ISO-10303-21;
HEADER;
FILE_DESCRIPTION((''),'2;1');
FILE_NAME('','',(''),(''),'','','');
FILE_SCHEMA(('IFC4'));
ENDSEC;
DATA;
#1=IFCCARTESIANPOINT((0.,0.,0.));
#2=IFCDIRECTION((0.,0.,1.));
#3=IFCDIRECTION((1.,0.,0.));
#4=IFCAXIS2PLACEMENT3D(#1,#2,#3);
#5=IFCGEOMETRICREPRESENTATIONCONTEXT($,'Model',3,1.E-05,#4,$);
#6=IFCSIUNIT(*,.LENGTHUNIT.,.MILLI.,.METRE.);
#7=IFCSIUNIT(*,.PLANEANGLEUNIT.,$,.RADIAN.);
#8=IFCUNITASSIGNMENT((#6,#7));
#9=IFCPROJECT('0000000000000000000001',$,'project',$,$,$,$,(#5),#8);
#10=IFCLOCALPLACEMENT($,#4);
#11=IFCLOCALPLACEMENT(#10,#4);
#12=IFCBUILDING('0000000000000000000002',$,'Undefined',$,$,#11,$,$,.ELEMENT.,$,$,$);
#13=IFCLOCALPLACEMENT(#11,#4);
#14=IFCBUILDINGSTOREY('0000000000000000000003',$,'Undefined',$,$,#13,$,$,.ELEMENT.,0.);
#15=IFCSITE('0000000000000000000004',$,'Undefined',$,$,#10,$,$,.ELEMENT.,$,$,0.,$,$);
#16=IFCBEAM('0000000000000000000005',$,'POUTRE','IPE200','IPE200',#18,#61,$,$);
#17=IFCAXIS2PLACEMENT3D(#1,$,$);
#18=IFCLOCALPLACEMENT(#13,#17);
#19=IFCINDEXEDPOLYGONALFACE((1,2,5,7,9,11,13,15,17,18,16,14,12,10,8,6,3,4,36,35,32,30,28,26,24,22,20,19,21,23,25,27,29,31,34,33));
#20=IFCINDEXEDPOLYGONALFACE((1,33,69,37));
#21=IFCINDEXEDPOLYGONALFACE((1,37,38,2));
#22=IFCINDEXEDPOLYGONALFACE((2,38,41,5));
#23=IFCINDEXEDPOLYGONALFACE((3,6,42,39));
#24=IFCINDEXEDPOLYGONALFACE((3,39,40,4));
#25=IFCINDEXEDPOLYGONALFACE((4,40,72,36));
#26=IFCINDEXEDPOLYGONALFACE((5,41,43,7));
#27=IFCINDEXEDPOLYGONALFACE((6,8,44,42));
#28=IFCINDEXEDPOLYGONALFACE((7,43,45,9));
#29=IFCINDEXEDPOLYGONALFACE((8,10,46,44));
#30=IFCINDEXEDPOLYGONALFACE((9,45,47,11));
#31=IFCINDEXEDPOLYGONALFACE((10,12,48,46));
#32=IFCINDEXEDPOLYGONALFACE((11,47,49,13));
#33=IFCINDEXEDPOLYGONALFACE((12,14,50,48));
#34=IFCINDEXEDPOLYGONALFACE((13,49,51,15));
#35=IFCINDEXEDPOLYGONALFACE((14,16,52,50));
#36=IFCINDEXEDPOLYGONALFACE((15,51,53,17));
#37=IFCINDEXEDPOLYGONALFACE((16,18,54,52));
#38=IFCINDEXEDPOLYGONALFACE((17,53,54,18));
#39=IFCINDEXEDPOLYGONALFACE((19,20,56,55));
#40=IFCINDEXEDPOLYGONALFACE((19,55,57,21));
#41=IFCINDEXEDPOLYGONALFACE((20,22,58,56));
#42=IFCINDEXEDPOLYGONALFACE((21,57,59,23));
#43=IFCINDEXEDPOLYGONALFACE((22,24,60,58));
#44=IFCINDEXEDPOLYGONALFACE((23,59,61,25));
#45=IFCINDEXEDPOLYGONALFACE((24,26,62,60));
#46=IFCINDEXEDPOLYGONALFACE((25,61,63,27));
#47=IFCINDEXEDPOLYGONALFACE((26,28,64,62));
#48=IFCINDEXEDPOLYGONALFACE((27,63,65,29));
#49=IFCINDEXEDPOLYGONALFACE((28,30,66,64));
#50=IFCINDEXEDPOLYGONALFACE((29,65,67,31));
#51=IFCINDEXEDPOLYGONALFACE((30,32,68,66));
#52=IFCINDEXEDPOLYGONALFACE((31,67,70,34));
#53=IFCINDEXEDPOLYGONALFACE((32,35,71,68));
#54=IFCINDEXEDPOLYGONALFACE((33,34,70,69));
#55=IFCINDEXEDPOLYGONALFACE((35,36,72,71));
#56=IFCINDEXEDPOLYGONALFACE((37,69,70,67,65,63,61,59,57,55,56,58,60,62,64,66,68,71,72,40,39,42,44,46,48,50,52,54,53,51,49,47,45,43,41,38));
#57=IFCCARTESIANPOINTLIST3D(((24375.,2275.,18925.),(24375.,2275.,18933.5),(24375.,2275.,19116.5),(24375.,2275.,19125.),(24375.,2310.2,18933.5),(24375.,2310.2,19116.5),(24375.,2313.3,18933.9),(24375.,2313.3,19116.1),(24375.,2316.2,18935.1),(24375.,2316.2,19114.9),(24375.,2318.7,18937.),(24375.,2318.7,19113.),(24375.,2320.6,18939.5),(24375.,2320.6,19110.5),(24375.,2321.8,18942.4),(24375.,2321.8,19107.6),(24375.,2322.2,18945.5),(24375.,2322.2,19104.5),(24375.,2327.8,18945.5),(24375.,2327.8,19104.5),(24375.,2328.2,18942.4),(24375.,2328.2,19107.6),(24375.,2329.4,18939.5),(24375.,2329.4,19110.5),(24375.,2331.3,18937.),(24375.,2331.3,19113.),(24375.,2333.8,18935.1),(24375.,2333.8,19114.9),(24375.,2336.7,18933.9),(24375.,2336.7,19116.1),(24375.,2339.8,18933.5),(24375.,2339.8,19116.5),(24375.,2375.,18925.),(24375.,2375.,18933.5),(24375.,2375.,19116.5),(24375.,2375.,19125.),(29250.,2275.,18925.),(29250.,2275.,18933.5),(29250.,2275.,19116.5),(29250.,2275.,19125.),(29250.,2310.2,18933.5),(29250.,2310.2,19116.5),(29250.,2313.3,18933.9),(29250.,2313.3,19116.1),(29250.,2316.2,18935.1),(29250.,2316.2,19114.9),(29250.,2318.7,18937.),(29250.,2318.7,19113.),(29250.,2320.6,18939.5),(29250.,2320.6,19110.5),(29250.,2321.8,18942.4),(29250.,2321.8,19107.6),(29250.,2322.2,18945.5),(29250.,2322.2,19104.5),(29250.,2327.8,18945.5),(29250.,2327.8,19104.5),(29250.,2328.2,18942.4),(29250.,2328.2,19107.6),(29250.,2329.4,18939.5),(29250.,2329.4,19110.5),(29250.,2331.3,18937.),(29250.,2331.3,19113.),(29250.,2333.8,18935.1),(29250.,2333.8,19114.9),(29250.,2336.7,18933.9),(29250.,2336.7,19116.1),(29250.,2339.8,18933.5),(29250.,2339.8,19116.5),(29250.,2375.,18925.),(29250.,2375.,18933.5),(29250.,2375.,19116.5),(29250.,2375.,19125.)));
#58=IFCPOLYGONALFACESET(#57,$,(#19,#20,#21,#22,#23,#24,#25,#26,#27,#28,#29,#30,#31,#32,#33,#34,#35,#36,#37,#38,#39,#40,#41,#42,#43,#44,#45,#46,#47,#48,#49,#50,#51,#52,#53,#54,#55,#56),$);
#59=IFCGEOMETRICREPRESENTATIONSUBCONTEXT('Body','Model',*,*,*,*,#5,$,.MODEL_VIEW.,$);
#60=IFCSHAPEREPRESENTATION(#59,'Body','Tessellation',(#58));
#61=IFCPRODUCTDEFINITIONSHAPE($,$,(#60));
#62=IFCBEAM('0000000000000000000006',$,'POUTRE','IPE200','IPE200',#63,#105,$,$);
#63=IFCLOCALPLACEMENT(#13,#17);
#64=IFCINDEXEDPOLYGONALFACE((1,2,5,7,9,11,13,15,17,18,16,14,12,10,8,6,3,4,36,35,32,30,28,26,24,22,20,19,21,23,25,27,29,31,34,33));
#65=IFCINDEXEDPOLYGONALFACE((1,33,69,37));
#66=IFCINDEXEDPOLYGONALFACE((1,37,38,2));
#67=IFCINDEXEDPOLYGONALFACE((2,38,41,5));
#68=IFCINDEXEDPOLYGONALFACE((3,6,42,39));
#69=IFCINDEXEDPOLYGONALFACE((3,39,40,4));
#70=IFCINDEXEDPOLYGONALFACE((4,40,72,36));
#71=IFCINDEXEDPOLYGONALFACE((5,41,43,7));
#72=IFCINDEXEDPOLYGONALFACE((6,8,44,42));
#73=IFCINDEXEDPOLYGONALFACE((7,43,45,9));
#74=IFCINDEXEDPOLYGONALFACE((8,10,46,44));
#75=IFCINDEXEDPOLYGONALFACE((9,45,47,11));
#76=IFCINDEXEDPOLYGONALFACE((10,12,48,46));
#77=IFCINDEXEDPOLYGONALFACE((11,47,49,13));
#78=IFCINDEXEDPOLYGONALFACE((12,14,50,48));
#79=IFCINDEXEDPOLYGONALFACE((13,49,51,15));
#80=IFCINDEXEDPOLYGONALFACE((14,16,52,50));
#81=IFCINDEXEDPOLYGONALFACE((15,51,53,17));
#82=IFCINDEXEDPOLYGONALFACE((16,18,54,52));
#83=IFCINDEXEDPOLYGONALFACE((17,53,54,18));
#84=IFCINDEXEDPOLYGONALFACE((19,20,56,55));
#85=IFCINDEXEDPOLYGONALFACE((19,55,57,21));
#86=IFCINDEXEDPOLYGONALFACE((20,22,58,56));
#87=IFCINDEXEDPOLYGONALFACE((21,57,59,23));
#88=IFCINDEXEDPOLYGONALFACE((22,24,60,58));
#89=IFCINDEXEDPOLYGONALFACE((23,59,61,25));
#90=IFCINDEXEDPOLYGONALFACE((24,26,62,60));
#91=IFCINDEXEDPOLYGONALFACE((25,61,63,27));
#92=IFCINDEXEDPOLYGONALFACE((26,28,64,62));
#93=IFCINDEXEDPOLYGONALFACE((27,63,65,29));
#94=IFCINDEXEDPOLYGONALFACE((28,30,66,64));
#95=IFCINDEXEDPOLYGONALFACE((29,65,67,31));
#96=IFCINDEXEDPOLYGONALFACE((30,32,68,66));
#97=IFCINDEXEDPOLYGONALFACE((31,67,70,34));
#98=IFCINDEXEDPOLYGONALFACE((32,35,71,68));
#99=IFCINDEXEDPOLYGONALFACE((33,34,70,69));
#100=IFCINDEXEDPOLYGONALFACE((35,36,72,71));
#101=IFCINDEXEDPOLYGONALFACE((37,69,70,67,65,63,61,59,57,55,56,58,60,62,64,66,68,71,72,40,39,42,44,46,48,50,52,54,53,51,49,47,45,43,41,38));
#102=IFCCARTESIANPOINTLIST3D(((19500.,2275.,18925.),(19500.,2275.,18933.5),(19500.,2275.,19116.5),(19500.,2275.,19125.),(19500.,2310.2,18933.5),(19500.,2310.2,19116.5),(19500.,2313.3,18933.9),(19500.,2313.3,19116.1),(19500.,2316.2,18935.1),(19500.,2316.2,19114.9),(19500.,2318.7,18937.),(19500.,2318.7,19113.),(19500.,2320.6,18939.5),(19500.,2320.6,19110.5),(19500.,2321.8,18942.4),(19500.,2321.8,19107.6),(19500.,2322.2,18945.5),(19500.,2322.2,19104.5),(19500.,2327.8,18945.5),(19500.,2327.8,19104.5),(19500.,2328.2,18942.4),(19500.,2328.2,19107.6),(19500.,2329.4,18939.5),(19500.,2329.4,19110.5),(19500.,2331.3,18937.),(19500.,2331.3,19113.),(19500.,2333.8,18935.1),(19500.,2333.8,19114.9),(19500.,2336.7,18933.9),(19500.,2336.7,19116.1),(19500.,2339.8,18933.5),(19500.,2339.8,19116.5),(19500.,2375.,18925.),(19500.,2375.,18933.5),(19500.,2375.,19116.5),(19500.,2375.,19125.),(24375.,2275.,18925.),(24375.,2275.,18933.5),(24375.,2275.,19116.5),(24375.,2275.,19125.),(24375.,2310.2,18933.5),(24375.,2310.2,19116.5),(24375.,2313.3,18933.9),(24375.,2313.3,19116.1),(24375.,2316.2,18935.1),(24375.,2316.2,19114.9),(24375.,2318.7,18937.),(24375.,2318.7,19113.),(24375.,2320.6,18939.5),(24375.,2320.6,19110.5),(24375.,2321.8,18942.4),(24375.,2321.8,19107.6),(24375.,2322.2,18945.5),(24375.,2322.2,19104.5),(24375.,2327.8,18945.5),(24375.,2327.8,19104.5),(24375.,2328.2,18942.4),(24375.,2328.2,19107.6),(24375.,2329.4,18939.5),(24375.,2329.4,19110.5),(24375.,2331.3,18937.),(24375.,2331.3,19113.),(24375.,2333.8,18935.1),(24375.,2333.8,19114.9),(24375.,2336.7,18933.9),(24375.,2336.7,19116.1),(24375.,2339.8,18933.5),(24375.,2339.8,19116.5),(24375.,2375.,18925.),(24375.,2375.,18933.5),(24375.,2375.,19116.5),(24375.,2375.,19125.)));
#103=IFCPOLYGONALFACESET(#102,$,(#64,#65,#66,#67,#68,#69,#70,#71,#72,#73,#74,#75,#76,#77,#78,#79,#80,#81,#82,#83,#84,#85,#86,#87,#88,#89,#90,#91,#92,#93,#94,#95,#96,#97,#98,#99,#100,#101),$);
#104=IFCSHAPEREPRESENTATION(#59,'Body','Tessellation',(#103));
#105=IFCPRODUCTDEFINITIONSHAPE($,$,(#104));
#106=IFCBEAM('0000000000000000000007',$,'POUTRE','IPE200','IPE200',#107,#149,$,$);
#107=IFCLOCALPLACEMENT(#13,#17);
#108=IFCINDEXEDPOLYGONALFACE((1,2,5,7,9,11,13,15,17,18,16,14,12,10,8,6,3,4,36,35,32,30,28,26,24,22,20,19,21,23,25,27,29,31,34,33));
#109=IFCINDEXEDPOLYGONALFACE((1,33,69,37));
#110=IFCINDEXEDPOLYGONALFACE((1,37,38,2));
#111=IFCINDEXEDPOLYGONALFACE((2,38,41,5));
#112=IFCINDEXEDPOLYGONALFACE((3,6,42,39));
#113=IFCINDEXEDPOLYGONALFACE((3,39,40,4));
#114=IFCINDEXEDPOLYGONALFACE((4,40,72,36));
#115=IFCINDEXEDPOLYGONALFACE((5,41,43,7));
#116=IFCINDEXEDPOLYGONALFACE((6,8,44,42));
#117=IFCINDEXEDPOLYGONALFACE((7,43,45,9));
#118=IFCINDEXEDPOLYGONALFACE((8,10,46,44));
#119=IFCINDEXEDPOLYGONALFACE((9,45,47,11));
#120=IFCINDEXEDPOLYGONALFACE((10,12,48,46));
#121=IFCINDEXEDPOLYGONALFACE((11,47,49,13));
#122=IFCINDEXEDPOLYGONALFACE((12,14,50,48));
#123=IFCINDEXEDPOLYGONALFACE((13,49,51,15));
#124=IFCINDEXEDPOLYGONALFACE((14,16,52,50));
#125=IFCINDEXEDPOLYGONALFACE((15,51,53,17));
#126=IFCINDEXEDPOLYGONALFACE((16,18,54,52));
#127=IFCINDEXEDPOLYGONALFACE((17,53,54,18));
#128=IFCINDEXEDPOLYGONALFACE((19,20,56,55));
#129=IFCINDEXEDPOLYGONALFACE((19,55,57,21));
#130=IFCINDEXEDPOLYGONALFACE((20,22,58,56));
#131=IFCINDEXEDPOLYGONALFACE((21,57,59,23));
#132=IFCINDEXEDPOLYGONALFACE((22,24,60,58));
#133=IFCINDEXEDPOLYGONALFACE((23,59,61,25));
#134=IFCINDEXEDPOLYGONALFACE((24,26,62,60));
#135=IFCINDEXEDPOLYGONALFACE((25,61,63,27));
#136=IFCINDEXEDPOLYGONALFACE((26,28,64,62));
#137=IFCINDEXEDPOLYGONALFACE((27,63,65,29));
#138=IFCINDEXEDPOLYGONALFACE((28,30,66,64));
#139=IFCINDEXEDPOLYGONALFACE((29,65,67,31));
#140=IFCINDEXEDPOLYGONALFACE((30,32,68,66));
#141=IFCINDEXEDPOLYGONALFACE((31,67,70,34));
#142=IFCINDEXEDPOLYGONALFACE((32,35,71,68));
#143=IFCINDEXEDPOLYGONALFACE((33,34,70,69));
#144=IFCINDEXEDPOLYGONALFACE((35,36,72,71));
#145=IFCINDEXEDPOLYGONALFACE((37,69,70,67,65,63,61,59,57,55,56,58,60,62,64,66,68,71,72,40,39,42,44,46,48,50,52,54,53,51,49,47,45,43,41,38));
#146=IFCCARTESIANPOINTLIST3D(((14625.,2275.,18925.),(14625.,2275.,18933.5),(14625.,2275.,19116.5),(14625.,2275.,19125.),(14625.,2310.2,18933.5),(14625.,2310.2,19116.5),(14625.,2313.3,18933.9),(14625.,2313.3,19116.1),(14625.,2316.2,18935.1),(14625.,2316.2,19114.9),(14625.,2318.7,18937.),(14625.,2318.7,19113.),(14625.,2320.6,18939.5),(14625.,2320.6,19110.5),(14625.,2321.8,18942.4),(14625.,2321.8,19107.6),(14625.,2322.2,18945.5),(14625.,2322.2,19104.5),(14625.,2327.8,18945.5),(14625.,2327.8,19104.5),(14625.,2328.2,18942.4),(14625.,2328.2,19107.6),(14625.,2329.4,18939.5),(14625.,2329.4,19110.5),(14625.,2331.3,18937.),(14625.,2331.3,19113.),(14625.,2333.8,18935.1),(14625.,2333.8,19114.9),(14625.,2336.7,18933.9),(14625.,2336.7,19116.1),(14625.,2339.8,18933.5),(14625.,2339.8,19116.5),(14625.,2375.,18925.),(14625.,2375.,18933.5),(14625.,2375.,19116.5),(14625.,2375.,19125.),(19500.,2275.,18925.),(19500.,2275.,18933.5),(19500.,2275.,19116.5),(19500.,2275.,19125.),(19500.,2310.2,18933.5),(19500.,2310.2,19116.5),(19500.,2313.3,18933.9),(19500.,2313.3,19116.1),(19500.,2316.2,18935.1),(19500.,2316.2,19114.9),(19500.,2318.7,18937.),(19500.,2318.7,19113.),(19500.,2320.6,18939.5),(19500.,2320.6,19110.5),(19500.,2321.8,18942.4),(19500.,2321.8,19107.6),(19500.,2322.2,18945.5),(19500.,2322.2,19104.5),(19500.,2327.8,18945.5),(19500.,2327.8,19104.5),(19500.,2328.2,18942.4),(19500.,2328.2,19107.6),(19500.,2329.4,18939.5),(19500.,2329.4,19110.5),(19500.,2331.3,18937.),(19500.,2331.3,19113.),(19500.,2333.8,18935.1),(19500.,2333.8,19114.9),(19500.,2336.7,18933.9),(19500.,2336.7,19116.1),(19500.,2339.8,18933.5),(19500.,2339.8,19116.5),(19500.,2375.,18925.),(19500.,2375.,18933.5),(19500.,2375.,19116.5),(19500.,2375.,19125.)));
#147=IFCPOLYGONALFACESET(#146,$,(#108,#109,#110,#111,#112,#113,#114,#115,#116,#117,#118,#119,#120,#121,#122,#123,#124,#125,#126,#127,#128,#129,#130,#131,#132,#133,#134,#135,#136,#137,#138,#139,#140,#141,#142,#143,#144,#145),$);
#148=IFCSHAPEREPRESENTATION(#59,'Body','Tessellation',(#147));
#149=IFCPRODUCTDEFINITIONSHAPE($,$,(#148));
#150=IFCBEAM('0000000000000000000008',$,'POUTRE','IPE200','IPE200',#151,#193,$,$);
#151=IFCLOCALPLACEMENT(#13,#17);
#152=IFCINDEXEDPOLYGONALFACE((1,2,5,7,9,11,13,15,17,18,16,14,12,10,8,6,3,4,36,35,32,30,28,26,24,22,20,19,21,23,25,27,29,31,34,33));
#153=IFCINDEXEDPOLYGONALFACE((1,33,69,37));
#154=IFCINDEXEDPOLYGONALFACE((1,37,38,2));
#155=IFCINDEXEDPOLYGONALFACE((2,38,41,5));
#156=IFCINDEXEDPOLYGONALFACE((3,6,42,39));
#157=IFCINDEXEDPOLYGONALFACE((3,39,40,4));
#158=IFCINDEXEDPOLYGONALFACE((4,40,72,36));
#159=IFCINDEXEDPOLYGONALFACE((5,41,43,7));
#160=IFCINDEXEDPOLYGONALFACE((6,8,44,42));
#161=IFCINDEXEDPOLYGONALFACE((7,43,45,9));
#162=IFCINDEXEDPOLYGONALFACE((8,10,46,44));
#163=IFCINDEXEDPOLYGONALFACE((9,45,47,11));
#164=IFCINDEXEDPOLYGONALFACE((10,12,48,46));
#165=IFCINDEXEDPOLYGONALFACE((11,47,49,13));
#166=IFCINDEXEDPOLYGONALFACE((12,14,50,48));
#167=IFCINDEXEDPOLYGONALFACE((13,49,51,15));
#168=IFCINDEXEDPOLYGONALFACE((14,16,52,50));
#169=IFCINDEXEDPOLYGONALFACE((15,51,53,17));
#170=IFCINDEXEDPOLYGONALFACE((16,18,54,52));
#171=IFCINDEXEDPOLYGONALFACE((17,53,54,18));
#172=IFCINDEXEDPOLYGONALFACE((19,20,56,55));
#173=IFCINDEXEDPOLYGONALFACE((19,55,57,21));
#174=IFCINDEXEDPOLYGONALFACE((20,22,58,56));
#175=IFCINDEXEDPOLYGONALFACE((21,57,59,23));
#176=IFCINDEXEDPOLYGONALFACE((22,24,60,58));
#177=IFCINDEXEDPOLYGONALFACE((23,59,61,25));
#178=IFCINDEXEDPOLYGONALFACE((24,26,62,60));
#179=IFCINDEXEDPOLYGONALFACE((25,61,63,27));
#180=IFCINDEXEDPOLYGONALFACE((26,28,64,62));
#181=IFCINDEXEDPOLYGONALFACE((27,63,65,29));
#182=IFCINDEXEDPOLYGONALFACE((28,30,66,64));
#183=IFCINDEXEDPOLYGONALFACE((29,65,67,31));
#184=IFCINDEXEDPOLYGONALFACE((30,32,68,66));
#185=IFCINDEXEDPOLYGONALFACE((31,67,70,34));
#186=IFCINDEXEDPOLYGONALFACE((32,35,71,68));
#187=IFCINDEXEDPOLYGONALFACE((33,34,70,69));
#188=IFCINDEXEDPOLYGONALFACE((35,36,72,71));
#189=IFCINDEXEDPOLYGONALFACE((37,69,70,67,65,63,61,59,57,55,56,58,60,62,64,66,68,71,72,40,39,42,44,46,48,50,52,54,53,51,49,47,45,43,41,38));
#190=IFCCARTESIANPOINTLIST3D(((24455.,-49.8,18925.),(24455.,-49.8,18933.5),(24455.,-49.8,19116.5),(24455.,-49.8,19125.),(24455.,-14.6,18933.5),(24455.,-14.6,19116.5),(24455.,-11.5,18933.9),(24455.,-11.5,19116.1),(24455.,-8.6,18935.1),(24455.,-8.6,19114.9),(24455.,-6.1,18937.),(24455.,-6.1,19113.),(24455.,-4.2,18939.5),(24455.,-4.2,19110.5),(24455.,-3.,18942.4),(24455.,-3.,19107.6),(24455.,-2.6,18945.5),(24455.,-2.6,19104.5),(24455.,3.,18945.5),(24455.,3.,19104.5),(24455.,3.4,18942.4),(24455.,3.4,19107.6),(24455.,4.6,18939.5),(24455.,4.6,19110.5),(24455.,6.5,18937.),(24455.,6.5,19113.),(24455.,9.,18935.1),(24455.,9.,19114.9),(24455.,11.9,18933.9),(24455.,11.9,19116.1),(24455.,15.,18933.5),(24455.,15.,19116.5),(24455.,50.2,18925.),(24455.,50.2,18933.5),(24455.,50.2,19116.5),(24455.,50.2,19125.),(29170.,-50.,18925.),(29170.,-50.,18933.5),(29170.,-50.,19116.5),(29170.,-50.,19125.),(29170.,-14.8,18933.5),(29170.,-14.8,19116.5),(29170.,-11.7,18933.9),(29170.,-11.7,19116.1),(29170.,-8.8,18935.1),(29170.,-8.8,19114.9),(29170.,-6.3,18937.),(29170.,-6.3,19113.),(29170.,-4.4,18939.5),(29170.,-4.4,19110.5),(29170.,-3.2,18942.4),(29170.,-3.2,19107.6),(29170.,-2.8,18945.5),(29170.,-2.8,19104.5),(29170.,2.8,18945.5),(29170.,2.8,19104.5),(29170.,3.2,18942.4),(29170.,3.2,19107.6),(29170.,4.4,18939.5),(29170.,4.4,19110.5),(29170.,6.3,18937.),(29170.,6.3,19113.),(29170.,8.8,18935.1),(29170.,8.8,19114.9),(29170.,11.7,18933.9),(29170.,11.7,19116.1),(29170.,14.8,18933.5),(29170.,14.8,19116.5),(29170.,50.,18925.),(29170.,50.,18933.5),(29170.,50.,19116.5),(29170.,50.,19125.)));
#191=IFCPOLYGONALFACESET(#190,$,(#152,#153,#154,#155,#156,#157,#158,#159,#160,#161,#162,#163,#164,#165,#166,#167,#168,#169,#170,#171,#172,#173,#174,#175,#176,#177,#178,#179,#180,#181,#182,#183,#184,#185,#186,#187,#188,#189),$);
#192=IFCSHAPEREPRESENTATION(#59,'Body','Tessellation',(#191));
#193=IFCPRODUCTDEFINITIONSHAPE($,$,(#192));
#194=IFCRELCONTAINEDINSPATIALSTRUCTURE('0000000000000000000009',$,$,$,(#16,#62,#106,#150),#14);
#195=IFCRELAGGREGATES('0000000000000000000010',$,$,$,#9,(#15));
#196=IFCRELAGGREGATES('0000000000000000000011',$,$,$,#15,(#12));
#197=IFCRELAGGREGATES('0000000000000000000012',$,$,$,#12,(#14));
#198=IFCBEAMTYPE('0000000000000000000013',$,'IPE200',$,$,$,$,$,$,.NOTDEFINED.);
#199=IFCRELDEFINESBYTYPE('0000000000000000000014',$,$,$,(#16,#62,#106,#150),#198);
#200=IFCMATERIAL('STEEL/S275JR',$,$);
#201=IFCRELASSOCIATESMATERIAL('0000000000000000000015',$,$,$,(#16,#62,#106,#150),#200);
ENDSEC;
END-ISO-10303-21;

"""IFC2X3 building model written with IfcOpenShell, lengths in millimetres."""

from ifc_helpers import new_model, si_unit, frame, origin_with_axes, origin_2d_with_axis, place, context, subcontext, project, spatial, i_section, extrude, material, type_object, element, save


model = new_model("IFC2X3")

# Units and contexts
model_context = context("Model", 3, precision=1e-05, world=origin_with_axes())
body_context = subcontext(model_context, "Body", "Model", "MODEL_VIEW")
ifc_project = project(units=[si_unit("LENGTHUNIT", "METRE", prefix="MILLI"), si_unit("PLANEANGLEUNIT", "RADIAN")], contexts=[model_context])

# Site, building, storey
site_placement = place(None, origin_with_axes())
site = spatial("IfcSite", under=ifc_project, at=site_placement, Name="Undefined", CompositionType="ELEMENT", RefElevation=0.0)
building_placement = place(site_placement, origin_with_axes())
building = spatial("IfcBuilding", under=site, at=building_placement, Name="Undefined", CompositionType="ELEMENT")
storey_placement = place(building_placement, origin_with_axes())
storey = spatial("IfcBuildingStorey", under=building, at=storey_placement, Name="Undefined", CompositionType="ELEMENT", Elevation=0.0)

# Shared definitions
ifc_material_1 = material(Name="STEEL/S275JR")

# Beams
beam_type_1 = type_object("IfcBeamType", Name="IPE200", PredefinedType="NOTDEFINED")
for number, where, z_axis, x_axis, name in (
    (1, (24375.0, 2325.0, 19025.0), (0.0, 0.0, 1.0), (1.0, 0.0, 0.0), "POUTRE"),
    (2, (19500.0, 2325.0, 19025.0), (0.0, 0.0, 1.0), (1.0, 0.0, 0.0), "POUTRE"),
    (3, (14625.0, 2325.0, 19025.0), (0.0, 0.0, 1.0), (1.0, 0.0, 0.0), "POUTRE"),
):
    element("IfcBeam", number, at=place(storey_placement, frame(where, z_axis=z_axis, x_axis=x_axis)), inside=storey, type_object=beam_type_1, material=ifc_material_1, Name=name, Description="IPE200", ObjectType="IPE200", context=body_context, shape_type="SweptSolid", body=[
        extrude(i_section(OverallWidth=100.0, OverallDepth=200.0, WebThickness=5.6, FlangeThickness=8.5, FilletRadius=12.0, at=origin_2d_with_axis()), frame((4875.0, 0.0, 0.0), z_axis=(-1.0, 0.0, 0.0), x_axis=(0.0, -1.0, 0.0)), (0.0, 0.0, 1.0), 4875.0),
    ])
beam_1_placement = place(storey_placement, frame((24375.0, 0.2, 19025.0), z_axis=(0.000006, 0.0, 1.0), x_axis=(1.0, -0.000043, -0.000006)))
element("IfcBeam", 4, at=beam_1_placement, inside=storey, type_object=beam_type_1, material=ifc_material_1, Name="POUTRE", Description="IPE200", ObjectType="IPE200", context=body_context, shape_type="SweptSolid", body=[
    extrude(i_section(OverallWidth=100.0, OverallDepth=200.0, WebThickness=5.6, FlangeThickness=8.5, FilletRadius=12.0, at=origin_2d_with_axis()), frame((4795.0, 0.0, 0.0), z_axis=(-1.0, 0.0, 0.0), x_axis=(0.0, -1.0, 0.0)), (0.0, 0.0, 1.0), 4715.0),
])

save(model, "model.ifc")
